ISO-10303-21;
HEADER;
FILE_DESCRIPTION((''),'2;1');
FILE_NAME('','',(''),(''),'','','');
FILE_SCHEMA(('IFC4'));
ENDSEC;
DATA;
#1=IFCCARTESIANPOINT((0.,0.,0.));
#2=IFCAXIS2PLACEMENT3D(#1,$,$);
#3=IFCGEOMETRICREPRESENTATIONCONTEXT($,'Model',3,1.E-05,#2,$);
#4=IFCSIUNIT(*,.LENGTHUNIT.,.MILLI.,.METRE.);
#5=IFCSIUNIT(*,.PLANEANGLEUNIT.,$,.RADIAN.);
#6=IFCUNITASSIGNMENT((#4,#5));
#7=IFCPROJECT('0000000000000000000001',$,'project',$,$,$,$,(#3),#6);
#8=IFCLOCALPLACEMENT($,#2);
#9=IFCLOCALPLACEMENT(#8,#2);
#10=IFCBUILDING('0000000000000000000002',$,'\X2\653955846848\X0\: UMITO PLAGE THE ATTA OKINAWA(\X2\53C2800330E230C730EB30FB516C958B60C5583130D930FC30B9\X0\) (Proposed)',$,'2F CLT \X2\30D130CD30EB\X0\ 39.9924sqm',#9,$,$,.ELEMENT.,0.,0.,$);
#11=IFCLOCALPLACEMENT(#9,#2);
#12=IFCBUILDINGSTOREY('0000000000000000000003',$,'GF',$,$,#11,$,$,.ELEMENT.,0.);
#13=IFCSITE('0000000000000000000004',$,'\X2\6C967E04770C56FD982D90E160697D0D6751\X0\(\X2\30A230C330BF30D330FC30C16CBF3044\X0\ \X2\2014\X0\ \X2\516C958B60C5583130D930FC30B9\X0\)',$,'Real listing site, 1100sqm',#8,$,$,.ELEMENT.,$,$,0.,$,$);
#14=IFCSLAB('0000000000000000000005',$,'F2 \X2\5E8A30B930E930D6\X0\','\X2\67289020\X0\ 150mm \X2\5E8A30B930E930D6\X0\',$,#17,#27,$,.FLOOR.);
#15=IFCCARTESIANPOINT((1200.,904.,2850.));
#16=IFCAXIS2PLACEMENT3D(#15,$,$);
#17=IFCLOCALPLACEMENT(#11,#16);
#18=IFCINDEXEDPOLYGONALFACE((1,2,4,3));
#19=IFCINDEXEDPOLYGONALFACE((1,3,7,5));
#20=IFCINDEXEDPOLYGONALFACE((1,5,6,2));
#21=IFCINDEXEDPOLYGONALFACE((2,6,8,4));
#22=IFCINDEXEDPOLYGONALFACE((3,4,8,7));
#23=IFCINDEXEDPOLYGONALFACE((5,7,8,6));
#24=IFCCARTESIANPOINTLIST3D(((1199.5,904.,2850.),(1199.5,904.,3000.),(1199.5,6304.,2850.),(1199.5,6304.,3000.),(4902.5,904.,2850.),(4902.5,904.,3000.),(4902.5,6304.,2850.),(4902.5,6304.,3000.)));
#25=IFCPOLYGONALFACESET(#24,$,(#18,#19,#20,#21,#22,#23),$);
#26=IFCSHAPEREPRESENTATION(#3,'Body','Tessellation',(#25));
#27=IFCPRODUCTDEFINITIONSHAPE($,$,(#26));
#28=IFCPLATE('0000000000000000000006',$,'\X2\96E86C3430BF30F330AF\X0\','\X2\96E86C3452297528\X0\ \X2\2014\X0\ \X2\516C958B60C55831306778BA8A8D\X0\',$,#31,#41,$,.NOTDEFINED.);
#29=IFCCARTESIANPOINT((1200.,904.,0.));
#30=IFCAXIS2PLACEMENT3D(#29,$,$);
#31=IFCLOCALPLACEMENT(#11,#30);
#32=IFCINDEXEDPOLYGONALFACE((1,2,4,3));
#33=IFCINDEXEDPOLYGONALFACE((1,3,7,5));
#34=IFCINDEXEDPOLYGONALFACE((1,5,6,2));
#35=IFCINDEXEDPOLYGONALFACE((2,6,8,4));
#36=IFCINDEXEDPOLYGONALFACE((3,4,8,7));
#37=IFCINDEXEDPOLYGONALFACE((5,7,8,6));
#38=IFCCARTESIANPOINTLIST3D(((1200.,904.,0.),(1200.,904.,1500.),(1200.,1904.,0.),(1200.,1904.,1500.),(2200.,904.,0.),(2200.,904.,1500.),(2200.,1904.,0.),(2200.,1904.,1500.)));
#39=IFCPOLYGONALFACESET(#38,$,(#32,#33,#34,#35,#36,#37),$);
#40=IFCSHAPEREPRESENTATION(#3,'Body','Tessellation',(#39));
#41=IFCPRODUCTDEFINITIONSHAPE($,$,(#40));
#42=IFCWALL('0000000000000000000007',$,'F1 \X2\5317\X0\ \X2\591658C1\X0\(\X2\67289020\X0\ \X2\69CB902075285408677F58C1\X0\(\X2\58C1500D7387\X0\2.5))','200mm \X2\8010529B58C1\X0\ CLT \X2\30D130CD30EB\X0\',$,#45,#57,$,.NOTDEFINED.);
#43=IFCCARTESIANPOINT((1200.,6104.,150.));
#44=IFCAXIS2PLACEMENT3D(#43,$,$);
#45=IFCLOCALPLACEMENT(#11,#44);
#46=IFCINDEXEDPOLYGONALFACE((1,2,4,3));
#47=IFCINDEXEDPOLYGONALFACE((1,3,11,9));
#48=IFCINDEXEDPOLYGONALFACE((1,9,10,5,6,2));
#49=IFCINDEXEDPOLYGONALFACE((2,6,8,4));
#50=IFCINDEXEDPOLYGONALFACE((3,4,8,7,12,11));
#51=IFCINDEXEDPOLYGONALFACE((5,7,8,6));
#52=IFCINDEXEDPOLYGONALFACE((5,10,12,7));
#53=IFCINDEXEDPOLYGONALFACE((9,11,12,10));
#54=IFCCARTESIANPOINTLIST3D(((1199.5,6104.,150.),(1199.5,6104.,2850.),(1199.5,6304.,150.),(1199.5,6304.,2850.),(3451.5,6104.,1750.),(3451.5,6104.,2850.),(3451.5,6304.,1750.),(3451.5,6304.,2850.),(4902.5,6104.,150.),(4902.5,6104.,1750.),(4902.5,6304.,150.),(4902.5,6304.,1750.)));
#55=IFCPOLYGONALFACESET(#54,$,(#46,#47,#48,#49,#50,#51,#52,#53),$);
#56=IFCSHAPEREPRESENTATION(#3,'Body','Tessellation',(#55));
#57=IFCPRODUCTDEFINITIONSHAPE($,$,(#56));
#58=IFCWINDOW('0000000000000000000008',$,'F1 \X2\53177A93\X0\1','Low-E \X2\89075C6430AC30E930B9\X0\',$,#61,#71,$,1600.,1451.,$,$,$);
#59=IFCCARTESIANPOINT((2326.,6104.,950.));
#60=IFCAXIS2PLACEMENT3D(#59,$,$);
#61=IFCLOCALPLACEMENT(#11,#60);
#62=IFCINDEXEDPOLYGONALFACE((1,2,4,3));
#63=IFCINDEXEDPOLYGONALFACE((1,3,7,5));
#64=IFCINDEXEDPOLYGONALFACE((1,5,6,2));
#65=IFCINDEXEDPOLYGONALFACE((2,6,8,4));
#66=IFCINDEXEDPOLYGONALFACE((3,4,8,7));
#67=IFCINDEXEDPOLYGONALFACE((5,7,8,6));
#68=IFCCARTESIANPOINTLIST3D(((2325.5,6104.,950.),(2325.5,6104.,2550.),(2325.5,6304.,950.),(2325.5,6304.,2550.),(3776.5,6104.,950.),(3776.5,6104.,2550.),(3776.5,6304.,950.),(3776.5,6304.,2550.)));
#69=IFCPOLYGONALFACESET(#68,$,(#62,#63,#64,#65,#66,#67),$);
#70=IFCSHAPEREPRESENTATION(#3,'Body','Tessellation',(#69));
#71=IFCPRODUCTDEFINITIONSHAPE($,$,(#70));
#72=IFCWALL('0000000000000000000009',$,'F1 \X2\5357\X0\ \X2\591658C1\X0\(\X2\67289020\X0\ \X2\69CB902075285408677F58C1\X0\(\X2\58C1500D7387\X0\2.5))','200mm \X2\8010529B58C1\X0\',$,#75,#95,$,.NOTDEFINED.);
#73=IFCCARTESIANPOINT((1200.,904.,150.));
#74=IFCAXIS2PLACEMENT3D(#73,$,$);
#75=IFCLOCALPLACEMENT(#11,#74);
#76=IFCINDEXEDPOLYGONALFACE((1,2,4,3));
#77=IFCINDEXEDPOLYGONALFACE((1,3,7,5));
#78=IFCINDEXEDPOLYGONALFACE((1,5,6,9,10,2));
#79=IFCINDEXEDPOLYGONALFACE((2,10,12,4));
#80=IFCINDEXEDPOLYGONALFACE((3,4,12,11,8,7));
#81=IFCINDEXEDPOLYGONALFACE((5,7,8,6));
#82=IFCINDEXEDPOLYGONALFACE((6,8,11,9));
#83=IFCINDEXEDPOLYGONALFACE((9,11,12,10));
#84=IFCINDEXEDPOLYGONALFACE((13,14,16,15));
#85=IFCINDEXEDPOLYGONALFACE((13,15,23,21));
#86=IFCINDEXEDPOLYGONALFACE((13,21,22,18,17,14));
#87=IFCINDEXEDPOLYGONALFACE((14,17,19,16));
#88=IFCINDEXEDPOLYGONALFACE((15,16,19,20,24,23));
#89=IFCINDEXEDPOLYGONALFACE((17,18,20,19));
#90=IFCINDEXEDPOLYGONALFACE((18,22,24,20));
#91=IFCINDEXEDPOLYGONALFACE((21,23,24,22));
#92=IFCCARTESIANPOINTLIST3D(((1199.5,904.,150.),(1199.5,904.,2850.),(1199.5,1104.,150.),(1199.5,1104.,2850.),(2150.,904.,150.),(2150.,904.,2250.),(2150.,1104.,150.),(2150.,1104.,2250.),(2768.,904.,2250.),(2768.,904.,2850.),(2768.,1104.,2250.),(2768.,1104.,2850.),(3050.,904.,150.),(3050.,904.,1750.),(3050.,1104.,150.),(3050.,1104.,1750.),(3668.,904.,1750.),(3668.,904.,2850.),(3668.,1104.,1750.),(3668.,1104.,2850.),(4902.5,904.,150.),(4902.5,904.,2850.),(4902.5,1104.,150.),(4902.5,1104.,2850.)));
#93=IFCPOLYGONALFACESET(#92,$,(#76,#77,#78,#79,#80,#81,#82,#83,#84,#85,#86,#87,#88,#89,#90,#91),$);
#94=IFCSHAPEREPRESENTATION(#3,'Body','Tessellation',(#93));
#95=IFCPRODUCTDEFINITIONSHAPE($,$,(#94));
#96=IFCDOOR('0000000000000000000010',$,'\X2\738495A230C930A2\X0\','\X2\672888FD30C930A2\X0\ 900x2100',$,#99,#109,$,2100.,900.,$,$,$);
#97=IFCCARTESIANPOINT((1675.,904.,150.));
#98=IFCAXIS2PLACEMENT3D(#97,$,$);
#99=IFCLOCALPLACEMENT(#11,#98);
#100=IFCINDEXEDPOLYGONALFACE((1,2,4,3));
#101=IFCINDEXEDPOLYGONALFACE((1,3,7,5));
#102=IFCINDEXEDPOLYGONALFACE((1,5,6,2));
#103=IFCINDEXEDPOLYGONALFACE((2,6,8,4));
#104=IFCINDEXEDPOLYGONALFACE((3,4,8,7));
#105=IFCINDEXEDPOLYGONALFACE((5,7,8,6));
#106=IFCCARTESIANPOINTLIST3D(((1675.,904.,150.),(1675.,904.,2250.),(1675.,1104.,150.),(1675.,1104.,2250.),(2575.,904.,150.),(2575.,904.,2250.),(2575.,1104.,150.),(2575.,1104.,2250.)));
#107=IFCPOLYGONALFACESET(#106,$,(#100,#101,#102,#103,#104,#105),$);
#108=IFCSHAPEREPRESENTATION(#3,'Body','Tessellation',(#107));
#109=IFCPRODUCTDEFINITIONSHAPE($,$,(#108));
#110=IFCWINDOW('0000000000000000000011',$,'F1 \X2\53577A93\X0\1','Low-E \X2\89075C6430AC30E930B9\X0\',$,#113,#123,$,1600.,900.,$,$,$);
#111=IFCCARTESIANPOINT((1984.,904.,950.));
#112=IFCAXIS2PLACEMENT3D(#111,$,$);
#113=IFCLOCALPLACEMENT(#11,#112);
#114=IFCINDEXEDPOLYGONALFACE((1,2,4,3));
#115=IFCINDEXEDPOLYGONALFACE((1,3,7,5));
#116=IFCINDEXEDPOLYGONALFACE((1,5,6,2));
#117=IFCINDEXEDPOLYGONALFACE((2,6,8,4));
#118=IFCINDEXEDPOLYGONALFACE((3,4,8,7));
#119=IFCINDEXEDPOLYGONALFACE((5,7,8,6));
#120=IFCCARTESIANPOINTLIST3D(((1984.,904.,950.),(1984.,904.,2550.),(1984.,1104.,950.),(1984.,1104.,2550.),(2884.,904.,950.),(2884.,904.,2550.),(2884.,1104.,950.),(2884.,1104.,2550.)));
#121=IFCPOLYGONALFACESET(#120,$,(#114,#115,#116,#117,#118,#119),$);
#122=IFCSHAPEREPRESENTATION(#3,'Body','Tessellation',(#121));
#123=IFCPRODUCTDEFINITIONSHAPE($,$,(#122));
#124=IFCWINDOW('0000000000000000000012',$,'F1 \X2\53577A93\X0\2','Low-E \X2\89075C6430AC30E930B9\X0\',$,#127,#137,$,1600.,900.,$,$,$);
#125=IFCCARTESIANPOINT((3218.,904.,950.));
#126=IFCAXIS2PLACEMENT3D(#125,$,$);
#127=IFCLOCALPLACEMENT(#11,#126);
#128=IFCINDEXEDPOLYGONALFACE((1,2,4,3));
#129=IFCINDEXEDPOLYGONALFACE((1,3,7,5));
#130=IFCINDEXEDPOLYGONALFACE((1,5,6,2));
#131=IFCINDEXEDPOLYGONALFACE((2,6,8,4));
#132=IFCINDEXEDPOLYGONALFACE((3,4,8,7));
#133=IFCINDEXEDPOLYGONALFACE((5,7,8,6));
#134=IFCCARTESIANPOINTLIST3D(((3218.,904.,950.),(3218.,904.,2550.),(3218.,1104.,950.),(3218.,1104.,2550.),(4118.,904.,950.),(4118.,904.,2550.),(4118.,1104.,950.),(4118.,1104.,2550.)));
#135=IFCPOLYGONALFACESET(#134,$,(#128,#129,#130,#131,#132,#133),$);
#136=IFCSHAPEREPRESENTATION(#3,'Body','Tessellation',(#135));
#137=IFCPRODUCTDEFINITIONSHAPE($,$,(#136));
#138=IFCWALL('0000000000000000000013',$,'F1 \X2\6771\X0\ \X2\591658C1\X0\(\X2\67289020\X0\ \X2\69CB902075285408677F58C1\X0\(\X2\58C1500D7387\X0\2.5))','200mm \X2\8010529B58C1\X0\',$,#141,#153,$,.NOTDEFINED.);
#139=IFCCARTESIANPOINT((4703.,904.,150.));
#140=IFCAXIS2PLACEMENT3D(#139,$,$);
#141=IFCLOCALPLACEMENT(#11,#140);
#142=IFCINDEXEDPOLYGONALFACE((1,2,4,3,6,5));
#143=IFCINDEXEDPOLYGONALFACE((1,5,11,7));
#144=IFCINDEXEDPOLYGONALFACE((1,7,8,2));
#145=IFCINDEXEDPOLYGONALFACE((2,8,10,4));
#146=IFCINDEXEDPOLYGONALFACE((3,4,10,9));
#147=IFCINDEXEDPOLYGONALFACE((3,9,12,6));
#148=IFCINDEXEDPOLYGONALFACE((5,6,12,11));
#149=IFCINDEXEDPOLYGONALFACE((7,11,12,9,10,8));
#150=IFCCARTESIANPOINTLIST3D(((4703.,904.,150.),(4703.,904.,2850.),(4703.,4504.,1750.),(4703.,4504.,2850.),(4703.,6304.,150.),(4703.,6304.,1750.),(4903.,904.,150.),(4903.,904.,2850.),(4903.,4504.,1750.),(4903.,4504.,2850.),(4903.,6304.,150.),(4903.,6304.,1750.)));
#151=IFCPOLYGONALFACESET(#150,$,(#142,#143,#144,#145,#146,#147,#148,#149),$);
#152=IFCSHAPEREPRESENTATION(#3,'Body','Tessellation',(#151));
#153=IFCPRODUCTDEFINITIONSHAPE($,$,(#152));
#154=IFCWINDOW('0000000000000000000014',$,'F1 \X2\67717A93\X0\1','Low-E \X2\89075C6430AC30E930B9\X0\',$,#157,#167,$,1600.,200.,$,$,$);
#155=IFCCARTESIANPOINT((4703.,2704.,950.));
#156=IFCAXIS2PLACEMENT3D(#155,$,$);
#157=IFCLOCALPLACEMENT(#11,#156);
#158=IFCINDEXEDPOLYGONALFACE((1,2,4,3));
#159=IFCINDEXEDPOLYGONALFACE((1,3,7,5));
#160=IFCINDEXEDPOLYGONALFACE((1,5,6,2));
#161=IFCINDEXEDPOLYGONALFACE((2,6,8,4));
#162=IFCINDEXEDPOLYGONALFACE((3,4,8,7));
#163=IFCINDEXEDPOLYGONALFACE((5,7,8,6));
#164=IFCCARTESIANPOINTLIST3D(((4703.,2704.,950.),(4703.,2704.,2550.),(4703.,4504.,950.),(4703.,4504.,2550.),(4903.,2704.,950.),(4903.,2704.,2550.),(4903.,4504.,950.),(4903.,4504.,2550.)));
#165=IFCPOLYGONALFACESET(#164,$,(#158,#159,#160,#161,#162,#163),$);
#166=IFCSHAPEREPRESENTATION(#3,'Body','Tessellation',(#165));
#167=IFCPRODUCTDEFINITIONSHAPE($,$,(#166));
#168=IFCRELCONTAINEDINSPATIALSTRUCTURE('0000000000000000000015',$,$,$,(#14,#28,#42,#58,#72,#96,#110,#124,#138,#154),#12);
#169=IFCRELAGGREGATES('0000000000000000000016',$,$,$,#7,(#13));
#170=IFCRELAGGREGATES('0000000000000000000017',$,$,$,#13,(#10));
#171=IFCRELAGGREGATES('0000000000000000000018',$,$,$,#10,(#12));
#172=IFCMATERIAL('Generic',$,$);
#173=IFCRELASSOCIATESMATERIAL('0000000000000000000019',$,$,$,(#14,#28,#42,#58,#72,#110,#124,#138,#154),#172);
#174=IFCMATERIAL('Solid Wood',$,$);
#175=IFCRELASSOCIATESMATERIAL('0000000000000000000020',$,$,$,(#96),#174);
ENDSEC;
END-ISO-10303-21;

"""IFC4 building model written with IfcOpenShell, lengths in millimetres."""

from ifc_helpers import new_model, si_unit, frame, frame_2d, origin, place, context, project, spatial, rectangle, extrude, material, element, fill, save


model = new_model("IFC4")

# Units and contexts
model_context = context("Model", 3, precision=1e-05, world=origin())
ifc_project = project(units=[si_unit("LENGTHUNIT", "METRE", prefix="MILLI"), si_unit("PLANEANGLEUNIT", "RADIAN")], contexts=[model_context])

# Site, building, storey
site_placement = place(None, origin())
site = spatial("IfcSite", under=ifc_project, at=site_placement, Name="沖縄県国頭郡恩納村(アッタビーチ沿い — 公開情報ベース)", ObjectType="Real listing site, 1100sqm", CompositionType="ELEMENT", RefElevation=0.0)
building_placement = place(site_placement, origin())
building = spatial("IfcBuilding", under=site, at=building_placement, Name="改善案: UMITO PLAGE THE ATTA OKINAWA(参考モデル・公開情報ベース) (Proposed)", ObjectType="2F CLT パネル 39.9924sqm", CompositionType="ELEMENT", ElevationOfRefHeight=0.0, ElevationOfTerrain=0.0)
storey_placement = place(building_placement, origin())
storey = spatial("IfcBuildingStorey", under=building, at=storey_placement, Name="GF", CompositionType="ELEMENT", Elevation=0.0)

# Slab
ifc_material_1 = material(Name="Generic")
slab_1_placement = place(storey_placement, frame((1200.0, 904.0, 2850.0)))
element("IfcSlab", 1, at=slab_1_placement, inside=storey, material=ifc_material_1, Name="F2 床スラブ", Description="木造 150mm 床スラブ", PredefinedType="FLOOR", context=model_context, shape_type="SweptSolid", body=[
    extrude(rectangle(XDim=3703.0, YDim=5400.0, at=frame_2d((1851.0, 2700.0))), frame((1200.0, 904.0, 2850.0)), (0.0, 0.0, 1.0), 150.0),
])

# Plate
plate_placement = place(storey_placement, frame((1200.0, 904.0, 0.0)))
element("IfcPlate", 2, at=plate_placement, inside=storey, material=ifc_material_1, Name="雨水タンク", Description="雨水利用 — 公開情報で確認", PredefinedType="NOTDEFINED", context=model_context, shape_type="SweptSolid", body=[
    extrude(rectangle(XDim=1000.0, YDim=1000.0, at=frame_2d((500.0, 500.0))), frame((1200.0, 904.0, 0.0)), (0.0, 0.0, 1.0), 1500.0),
])

# Wall, opening, window
wall_1_placement = place(storey_placement, frame((1200.0, 6104.0, 150.0)))
wall_1 = element("IfcWall", 3, at=wall_1_placement, inside=storey, material=ifc_material_1, Name="F1 北 外壁(木造 構造用合板壁(壁倍率2.5))", Description="200mm 耐力壁 CLT パネル", PredefinedType="NOTDEFINED", context=model_context, shape_type="SweptSolid", body=[
    extrude(rectangle(XDim=3703.0, YDim=200.0, at=frame_2d((1851.0, 100.0))), frame((1200.0, 6104.0, 150.0)), (0.0, 0.0, 1.0), 2700.0),
])
opening_1_placement = place(storey_placement, frame((2326.0, 6104.0, 950.0)))
opening_1 = element("IfcOpeningElement", 4, at=opening_1_placement, cuts=wall_1, PredefinedType="NOTDEFINED", context=model_context, shape_type="SweptSolid", body=[
    extrude(rectangle(XDim=1451.0, YDim=200.0, at=frame_2d((725.0, 100.0))), frame((2326.0, 6104.0, 950.0)), (0.0, 0.0, 1.0), 1600.0),
])
window_1_placement = place(storey_placement, frame((2326.0, 6104.0, 950.0)))
window_1 = element("IfcWindow", 5, at=window_1_placement, inside=storey, material=ifc_material_1, Name="F1 北窓1", Description="Low-E 複層ガラス", OverallHeight=1600.0, OverallWidth=1451.0, context=model_context, shape_type="SweptSolid", body=[
    extrude(rectangle(XDim=1451.0, YDim=200.0, at=frame_2d((725.0, 100.0))), frame((2326.0, 6104.0, 950.0)), (0.0, 0.0, 1.0), 1600.0),
])
fill(opening_1, window_1)

# Wall, openings, door, windows
wall_2_placement = place(storey_placement, frame((1200.0, 904.0, 150.0)))
wall_2 = element("IfcWall", 6, at=wall_2_placement, inside=storey, material=ifc_material_1, Name="F1 南 外壁(木造 構造用合板壁(壁倍率2.5))", Description="200mm 耐力壁", PredefinedType="NOTDEFINED", context=model_context, shape_type="SweptSolid", body=[
    extrude(rectangle(XDim=3703.0, YDim=200.0, at=frame_2d((1851.0, 100.0))), frame((1200.0, 904.0, 150.0)), (0.0, 0.0, 1.0), 2700.0),
])
opening_2_placement = place(storey_placement, frame((1675.0, 904.0, 150.0)))
opening_2 = element("IfcOpeningElement", 7, at=opening_2_placement, cuts=wall_2, PredefinedType="NOTDEFINED", context=model_context, shape_type="SweptSolid", body=[
    extrude(rectangle(XDim=900.0, YDim=200.0, at=frame_2d((450.0, 100.0))), frame((1675.0, 904.0, 150.0)), (0.0, 0.0, 1.0), 2100.0),
])
opening_3_placement = place(storey_placement, frame((1984.0, 904.0, 950.0)))
opening_3 = element("IfcOpeningElement", 8, at=opening_3_placement, cuts=wall_2, PredefinedType="NOTDEFINED", context=model_context, shape_type="SweptSolid", body=[
    extrude(rectangle(XDim=900.0, YDim=200.0, at=frame_2d((450.0, 100.0))), frame((1984.0, 904.0, 950.0)), (0.0, 0.0, 1.0), 1600.0),
])
opening_4_placement = place(storey_placement, frame((3218.0, 904.0, 950.0)))
opening_4 = element("IfcOpeningElement", 9, at=opening_4_placement, cuts=wall_2, PredefinedType="NOTDEFINED", context=model_context, shape_type="SweptSolid", body=[
    extrude(rectangle(XDim=900.0, YDim=200.0, at=frame_2d((450.0, 100.0))), frame((3218.0, 904.0, 950.0)), (0.0, 0.0, 1.0), 1600.0),
])
ifc_material_2 = material(Name="Solid Wood")
door_placement = place(storey_placement, frame((1675.0, 904.0, 150.0)))
door = element("IfcDoor", 10, at=door_placement, inside=storey, material=ifc_material_2, Name="玄関ドア", Description="木製ドア 900x2100", OverallHeight=2100.0, OverallWidth=900.0, context=model_context, shape_type="SweptSolid", body=[
    extrude(rectangle(XDim=900.0, YDim=200.0, at=frame_2d((450.0, 100.0))), frame((1675.0, 904.0, 150.0)), (0.0, 0.0, 1.0), 2100.0),
])
fill(opening_2, door)
window_2_placement = place(storey_placement, frame((1984.0, 904.0, 950.0)))
window_2 = element("IfcWindow", 11, at=window_2_placement, inside=storey, material=ifc_material_1, Name="F1 南窓1", Description="Low-E 複層ガラス", OverallHeight=1600.0, OverallWidth=900.0, context=model_context, shape_type="SweptSolid", body=[
    extrude(rectangle(XDim=900.0, YDim=200.0, at=frame_2d((450.0, 100.0))), frame((1984.0, 904.0, 950.0)), (0.0, 0.0, 1.0), 1600.0),
])
fill(opening_3, window_2)
window_3_placement = place(storey_placement, frame((3218.0, 904.0, 950.0)))
window_3 = element("IfcWindow", 12, at=window_3_placement, inside=storey, material=ifc_material_1, Name="F1 南窓2", Description="Low-E 複層ガラス", OverallHeight=1600.0, OverallWidth=900.0, context=model_context, shape_type="SweptSolid", body=[
    extrude(rectangle(XDim=900.0, YDim=200.0, at=frame_2d((450.0, 100.0))), frame((3218.0, 904.0, 950.0)), (0.0, 0.0, 1.0), 1600.0),
])
fill(opening_4, window_3)

# Wall, opening, window
wall_3_placement = place(storey_placement, frame((4703.0, 904.0, 150.0)))
wall_3 = element("IfcWall", 13, at=wall_3_placement, inside=storey, material=ifc_material_1, Name="F1 東 外壁(木造 構造用合板壁(壁倍率2.5))", Description="200mm 耐力壁", PredefinedType="NOTDEFINED", context=model_context, shape_type="SweptSolid", body=[
    extrude(rectangle(XDim=200.0, YDim=5400.0, at=frame_2d((100.0, 2700.0))), frame((4703.0, 904.0, 150.0)), (0.0, 0.0, 1.0), 2700.0),
])
opening_5_placement = place(storey_placement, frame((4703.0, 2704.0, 950.0)))
opening_5 = element("IfcOpeningElement", 14, at=opening_5_placement, cuts=wall_3, PredefinedType="NOTDEFINED", context=model_context, shape_type="SweptSolid", body=[
    extrude(rectangle(XDim=200.0, YDim=1800.0, at=frame_2d((100.0, 900.0))), frame((4703.0, 2704.0, 950.0)), (0.0, 0.0, 1.0), 1600.0),
])
window_4_placement = place(storey_placement, frame((4703.0, 2704.0, 950.0)))
window_4 = element("IfcWindow", 15, at=window_4_placement, inside=storey, material=ifc_material_1, Name="F1 東窓1", Description="Low-E 複層ガラス", OverallHeight=1600.0, OverallWidth=200.0, context=model_context, shape_type="SweptSolid", body=[
    extrude(rectangle(XDim=200.0, YDim=1800.0, at=frame_2d((100.0, 900.0))), frame((4703.0, 2704.0, 950.0)), (0.0, 0.0, 1.0), 1600.0),
])
fill(opening_5, window_4)

save(model, "model.ifc")
